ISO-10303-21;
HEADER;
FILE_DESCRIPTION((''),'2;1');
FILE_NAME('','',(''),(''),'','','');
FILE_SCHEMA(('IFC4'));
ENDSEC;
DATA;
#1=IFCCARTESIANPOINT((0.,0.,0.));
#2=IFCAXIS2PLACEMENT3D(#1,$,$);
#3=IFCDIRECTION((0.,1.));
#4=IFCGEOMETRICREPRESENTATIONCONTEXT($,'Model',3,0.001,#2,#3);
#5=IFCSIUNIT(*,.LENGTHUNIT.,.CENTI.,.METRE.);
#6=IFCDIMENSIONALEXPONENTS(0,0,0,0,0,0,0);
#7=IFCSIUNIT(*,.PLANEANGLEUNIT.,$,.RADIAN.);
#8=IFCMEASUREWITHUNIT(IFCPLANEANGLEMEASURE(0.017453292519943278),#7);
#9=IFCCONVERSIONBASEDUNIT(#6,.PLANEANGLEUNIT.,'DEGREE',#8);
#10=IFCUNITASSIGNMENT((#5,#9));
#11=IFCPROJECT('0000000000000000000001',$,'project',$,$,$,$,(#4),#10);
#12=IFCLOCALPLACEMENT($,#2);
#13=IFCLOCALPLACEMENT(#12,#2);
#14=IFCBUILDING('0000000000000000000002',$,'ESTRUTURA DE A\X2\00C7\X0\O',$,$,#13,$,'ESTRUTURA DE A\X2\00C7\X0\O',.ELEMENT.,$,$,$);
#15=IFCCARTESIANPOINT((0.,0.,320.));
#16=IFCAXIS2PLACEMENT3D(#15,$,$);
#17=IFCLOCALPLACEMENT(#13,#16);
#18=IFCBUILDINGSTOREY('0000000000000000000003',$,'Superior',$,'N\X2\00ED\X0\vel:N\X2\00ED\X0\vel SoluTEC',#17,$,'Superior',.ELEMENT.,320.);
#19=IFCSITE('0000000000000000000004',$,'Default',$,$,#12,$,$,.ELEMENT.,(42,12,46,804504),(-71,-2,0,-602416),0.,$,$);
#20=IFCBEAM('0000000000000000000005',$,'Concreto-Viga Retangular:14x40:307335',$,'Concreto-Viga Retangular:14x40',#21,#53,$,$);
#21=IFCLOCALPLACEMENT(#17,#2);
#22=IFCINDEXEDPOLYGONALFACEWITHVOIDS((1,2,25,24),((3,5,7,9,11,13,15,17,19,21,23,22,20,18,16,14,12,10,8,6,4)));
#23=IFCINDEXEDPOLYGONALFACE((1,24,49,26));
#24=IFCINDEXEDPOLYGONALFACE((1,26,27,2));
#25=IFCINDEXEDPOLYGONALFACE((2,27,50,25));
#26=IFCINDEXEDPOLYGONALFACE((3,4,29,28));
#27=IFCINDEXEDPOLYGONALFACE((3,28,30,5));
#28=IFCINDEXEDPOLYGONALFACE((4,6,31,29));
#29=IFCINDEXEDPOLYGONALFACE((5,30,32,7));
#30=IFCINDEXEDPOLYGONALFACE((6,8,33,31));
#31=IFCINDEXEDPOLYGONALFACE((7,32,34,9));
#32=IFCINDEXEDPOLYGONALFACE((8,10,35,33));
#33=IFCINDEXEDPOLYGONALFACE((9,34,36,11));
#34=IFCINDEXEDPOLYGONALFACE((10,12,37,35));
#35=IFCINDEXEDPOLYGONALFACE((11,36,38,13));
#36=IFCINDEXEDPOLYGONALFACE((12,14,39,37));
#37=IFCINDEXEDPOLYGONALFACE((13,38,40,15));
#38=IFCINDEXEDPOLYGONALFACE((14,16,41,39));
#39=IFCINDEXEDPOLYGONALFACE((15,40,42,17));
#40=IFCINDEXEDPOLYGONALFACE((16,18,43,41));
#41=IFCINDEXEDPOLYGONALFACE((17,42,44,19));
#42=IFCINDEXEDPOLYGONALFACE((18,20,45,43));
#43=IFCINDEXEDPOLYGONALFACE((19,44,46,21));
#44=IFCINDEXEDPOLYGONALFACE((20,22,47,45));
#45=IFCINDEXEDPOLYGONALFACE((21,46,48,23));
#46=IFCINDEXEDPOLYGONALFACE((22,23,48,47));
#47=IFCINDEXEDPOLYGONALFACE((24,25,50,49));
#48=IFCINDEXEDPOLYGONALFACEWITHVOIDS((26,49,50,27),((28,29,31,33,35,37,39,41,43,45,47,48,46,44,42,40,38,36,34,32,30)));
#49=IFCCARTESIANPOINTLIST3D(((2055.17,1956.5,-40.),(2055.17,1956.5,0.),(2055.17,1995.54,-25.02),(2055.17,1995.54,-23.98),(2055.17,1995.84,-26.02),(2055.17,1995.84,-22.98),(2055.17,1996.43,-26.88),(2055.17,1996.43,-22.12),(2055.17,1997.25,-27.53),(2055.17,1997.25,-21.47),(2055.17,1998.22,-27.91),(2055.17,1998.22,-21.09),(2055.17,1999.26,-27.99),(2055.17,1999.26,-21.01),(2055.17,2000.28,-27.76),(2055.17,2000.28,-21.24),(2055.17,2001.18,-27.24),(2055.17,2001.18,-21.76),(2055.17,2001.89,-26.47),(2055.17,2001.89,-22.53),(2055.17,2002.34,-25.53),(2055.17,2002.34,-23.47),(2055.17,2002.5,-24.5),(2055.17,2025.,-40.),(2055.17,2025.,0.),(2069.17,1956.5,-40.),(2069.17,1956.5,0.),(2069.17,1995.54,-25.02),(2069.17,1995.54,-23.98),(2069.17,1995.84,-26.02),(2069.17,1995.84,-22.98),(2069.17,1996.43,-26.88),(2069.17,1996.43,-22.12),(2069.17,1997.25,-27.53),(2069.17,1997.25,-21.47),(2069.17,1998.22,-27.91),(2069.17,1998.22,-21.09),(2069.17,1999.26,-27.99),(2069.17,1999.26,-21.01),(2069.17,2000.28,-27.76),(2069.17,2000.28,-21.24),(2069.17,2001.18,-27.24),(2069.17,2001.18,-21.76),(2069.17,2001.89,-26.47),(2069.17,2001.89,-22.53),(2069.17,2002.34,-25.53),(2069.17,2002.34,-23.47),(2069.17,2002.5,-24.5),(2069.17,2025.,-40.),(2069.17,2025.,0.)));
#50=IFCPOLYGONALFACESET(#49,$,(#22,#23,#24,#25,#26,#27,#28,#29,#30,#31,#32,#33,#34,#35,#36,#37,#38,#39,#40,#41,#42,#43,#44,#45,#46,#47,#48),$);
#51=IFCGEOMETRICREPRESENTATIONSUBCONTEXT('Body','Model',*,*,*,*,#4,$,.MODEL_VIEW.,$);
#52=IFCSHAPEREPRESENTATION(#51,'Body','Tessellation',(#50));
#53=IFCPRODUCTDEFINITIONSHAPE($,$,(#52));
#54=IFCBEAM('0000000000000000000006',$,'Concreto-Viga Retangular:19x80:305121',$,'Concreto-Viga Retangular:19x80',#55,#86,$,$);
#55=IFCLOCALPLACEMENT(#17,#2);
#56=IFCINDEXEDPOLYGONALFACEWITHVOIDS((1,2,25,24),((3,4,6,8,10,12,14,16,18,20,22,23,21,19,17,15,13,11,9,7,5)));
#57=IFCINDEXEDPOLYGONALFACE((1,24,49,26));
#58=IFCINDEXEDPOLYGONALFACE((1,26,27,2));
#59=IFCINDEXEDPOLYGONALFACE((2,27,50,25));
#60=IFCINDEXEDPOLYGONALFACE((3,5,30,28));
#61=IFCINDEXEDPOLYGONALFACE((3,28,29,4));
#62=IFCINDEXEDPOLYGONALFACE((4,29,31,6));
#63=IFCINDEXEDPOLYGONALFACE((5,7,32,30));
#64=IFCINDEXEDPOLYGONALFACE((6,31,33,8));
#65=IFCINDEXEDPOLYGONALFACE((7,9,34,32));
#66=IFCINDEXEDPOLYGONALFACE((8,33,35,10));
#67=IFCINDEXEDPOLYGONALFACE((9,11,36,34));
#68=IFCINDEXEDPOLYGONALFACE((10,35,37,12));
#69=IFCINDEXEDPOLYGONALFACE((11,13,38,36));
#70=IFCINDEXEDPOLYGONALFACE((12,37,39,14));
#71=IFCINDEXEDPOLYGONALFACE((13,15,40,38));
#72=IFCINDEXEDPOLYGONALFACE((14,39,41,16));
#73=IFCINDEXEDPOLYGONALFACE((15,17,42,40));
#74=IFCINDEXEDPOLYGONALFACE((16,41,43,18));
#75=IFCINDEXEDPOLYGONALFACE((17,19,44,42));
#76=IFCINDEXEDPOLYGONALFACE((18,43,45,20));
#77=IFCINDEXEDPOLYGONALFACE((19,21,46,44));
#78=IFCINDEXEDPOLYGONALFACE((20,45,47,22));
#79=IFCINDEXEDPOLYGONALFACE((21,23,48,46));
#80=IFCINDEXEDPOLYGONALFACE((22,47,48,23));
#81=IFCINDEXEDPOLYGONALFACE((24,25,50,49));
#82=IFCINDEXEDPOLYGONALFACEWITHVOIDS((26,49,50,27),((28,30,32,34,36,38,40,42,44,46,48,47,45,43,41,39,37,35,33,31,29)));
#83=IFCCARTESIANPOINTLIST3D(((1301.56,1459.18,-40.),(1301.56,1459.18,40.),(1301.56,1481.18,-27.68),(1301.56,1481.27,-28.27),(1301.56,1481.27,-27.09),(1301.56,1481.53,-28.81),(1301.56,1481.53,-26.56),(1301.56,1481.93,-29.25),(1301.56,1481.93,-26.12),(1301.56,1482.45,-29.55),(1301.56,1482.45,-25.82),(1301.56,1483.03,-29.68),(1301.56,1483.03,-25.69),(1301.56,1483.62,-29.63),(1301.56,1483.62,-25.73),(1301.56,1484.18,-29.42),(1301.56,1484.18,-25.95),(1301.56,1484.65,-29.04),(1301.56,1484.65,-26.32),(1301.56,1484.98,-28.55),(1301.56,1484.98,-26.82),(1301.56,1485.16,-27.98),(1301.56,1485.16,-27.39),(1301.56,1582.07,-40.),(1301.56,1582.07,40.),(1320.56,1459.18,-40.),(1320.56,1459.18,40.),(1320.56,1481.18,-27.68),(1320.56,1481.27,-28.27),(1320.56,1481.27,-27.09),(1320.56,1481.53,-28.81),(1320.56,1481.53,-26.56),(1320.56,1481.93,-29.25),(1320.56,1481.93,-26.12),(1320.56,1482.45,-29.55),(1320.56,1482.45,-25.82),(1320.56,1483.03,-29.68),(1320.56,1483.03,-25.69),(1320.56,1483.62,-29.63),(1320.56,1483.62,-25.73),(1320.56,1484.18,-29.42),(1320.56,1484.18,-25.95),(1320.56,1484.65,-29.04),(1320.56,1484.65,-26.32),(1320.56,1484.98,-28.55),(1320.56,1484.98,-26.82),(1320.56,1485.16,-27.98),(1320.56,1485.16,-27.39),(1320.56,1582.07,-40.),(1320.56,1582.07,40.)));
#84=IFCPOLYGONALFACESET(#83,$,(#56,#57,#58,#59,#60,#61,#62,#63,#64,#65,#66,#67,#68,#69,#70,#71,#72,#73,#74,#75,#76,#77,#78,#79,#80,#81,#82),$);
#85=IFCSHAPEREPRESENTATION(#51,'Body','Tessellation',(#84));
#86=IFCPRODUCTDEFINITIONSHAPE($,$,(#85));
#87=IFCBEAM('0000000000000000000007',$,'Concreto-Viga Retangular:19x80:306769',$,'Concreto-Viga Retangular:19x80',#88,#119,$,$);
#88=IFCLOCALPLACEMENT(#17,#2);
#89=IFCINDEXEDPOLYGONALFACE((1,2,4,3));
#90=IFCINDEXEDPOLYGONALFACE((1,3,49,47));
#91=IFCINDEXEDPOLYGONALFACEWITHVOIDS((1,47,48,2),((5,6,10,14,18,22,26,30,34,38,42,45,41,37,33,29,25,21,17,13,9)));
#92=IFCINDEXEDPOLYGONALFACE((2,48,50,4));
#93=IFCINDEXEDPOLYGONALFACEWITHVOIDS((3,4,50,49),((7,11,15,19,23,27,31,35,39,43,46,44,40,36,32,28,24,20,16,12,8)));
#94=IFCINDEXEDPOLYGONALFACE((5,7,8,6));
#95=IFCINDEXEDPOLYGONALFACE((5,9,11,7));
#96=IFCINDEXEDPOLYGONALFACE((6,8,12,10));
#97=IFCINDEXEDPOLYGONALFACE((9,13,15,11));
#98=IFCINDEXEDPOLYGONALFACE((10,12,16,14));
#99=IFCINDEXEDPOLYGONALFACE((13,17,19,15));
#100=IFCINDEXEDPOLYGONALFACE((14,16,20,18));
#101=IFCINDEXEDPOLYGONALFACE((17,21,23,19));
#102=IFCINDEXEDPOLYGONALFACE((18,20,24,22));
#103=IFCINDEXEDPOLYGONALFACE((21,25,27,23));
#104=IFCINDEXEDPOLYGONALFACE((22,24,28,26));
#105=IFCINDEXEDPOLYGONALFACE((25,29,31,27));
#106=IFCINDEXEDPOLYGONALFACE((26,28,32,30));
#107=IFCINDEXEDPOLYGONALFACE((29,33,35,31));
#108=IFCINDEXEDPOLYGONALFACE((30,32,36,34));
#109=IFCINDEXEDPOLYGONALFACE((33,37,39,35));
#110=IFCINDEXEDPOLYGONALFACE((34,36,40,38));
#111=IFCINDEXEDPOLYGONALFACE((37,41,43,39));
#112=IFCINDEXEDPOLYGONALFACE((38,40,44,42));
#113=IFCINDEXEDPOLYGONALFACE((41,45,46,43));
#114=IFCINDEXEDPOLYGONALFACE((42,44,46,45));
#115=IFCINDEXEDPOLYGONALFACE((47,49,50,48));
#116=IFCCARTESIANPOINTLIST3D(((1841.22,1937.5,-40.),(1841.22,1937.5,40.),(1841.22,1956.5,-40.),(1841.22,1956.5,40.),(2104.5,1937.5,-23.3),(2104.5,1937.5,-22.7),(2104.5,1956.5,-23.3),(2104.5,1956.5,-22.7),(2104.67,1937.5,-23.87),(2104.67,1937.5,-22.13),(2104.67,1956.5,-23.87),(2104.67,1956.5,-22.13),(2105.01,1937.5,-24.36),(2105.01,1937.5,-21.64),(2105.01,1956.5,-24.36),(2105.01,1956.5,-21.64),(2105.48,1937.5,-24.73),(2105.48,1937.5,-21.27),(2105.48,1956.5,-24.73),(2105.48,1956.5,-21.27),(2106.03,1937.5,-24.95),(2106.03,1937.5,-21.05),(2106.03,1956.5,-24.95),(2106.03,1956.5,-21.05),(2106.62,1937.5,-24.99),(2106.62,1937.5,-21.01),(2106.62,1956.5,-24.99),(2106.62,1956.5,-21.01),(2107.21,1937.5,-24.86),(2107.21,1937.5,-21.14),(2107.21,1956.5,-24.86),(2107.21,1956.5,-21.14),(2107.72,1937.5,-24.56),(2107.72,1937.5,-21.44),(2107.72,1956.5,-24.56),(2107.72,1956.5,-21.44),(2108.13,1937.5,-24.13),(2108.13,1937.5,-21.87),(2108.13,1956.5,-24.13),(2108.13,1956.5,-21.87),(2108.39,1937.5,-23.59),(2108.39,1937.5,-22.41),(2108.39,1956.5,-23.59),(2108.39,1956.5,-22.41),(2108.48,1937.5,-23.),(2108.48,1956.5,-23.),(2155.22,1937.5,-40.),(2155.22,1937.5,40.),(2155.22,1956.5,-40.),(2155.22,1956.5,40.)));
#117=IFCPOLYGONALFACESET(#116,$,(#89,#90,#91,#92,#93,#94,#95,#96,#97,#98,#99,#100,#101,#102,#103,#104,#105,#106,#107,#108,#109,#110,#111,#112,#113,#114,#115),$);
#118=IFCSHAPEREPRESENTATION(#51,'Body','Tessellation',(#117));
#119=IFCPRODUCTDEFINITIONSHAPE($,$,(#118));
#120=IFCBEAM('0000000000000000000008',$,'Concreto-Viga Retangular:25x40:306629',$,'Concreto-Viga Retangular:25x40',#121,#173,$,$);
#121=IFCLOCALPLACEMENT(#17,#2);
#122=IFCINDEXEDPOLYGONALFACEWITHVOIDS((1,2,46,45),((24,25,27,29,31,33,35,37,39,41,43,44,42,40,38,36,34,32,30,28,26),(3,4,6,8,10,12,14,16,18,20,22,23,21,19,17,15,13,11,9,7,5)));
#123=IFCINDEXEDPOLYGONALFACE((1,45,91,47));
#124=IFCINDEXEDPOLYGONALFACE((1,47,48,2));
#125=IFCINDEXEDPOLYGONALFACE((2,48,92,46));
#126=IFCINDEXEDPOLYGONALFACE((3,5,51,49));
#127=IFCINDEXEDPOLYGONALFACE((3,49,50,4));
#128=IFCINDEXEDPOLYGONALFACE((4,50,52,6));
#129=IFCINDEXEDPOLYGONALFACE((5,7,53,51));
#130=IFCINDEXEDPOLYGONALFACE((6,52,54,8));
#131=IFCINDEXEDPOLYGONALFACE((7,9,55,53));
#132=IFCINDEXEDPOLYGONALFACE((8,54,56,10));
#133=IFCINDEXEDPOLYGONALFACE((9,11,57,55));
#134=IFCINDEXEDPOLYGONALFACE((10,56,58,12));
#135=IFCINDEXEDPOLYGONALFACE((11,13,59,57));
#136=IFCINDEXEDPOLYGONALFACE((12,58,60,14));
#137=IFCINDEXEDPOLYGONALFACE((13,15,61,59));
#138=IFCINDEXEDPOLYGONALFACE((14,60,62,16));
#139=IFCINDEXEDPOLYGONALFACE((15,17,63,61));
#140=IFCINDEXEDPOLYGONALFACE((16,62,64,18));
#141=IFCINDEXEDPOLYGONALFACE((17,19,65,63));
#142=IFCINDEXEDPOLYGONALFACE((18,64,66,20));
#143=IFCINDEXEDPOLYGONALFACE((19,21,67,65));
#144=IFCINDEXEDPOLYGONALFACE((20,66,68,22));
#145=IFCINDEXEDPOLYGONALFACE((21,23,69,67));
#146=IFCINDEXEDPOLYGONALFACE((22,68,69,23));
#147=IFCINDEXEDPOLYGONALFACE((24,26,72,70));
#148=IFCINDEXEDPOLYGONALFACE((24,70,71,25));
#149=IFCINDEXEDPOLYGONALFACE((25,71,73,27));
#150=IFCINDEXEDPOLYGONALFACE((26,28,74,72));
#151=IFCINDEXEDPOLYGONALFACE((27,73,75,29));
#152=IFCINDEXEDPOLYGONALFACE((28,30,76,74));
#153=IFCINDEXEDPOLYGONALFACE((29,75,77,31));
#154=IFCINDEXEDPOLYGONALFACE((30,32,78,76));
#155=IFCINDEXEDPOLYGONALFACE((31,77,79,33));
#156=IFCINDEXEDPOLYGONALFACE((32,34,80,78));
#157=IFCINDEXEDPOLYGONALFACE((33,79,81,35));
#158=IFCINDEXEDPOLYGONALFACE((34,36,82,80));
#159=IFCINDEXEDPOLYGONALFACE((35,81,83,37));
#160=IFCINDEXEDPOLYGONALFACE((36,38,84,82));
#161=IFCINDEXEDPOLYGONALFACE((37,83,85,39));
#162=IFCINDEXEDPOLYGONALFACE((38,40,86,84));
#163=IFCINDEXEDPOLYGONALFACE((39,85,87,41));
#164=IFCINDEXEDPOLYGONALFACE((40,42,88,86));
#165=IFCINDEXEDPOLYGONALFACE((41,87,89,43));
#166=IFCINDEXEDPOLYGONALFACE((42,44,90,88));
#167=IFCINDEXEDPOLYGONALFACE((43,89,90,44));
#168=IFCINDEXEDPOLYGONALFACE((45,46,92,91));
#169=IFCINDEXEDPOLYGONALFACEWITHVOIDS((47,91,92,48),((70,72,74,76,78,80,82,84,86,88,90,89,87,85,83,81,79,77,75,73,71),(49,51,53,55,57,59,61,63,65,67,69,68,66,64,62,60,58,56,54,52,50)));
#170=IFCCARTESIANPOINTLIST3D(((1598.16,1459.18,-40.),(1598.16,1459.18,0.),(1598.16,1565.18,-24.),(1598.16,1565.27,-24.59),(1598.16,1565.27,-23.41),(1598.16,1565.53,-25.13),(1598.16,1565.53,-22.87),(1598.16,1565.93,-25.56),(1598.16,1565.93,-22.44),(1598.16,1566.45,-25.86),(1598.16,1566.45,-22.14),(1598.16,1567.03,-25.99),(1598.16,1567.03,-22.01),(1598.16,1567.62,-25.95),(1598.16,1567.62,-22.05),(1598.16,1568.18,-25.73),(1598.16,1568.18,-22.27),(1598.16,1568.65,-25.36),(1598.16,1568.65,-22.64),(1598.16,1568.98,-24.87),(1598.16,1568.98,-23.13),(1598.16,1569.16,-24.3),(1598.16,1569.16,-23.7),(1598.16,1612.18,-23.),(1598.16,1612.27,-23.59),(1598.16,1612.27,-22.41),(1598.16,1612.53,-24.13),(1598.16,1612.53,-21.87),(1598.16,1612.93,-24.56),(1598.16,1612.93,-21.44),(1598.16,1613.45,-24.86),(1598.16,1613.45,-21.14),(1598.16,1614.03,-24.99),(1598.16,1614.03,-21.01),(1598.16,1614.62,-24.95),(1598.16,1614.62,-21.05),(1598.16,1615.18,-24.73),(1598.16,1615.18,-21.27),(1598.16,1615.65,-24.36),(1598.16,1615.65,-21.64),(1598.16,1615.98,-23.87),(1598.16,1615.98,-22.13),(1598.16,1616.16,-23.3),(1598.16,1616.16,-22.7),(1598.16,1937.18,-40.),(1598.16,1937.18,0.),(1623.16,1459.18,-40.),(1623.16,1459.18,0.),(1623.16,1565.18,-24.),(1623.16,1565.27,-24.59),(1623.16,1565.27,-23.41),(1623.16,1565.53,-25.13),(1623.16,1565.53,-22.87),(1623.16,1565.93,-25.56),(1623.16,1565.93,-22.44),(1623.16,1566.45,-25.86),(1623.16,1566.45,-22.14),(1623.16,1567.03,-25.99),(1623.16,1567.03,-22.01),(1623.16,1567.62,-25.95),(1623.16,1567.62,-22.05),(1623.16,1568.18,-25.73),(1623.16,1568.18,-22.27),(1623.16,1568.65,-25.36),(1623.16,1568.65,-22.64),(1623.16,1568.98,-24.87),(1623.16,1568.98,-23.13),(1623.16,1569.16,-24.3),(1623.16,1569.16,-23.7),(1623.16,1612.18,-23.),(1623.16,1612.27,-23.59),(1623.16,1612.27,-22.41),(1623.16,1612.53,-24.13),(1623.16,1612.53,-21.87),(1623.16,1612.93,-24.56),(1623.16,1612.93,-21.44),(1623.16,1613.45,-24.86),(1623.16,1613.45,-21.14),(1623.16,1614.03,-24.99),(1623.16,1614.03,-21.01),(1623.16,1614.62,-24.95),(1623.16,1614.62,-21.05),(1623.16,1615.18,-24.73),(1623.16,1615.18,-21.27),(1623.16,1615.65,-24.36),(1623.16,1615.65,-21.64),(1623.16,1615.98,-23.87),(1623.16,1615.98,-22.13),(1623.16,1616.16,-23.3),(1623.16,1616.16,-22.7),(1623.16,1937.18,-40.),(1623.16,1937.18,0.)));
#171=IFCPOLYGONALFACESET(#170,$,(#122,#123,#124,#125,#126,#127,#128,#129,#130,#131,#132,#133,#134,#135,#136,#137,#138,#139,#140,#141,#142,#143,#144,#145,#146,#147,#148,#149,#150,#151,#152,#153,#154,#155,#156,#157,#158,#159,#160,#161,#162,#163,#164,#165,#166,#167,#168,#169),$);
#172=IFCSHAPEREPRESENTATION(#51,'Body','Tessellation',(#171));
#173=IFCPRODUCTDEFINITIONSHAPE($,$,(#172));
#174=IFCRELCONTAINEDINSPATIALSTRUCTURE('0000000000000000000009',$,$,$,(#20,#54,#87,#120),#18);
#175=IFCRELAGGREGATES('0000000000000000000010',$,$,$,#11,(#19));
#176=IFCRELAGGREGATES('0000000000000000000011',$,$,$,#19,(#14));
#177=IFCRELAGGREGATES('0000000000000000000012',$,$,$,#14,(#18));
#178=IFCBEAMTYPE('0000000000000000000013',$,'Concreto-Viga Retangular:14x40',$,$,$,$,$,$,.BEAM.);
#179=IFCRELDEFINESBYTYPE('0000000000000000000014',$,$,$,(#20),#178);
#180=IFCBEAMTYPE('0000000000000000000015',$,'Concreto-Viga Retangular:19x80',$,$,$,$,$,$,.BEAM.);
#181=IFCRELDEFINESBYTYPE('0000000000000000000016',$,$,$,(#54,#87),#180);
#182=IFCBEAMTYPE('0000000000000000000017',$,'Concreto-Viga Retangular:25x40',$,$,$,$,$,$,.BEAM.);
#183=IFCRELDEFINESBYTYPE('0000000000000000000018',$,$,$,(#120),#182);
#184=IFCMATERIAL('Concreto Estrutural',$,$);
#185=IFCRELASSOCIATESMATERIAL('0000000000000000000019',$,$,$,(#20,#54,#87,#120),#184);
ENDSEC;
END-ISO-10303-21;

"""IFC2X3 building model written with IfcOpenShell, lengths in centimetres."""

from ifc_helpers import new_model, entity, si_unit, converted_unit, direction, frame, frame_2d, origin, origin_2d_with_axis, place, context, subcontext, project, spatial, rectangle, circle, extrude, boolean, material, type_object, element, save


model = new_model("IFC2X3")

# Units and contexts
model_context = context("Model", 3, precision=0.001, world=origin(), true_north=direction((0.0, 1.0)))
body_context = subcontext(model_context, "Body", "Model", "MODEL_VIEW")
ifc_project = project(units=[si_unit("LENGTHUNIT", "METRE", prefix="CENTI"), converted_unit("PLANEANGLEUNIT", "DEGREE", entity("IfcPlaneAngleMeasure", 0.017453292519943278), si_unit("PLANEANGLEUNIT", "RADIAN"), dimensions=[0, 0, 0, 0, 0, 0, 0])], contexts=[model_context])

# Site, building, storey
site_placement = place(None, origin())
site = spatial("IfcSite", under=ifc_project, at=site_placement, Name="Default", CompositionType="ELEMENT", RefLatitude=(42, 12, 46, 804504), RefLongitude=(-71, -2, 0, -602416), RefElevation=0.0)
building_placement = place(site_placement, origin())
building = spatial("IfcBuilding", under=site, at=building_placement, Name="ESTRUTURA DE AÇO", LongName="ESTRUTURA DE AÇO", CompositionType="ELEMENT")
storey_placement = place(building_placement, frame((0.0, 0.0, 320.0)))
storey = spatial("IfcBuildingStorey", under=building, at=storey_placement, Name="Superior", ObjectType="Nível:Nível SoluTEC", LongName="Superior", CompositionType="ELEMENT", Elevation=320.0)

# Shared definitions
ifc_material = material(Name="Concreto Estrutural")

# Beams
beam_type_1 = type_object("IfcBeamType", Name="Concreto-Viga Retangular:14x40", PredefinedType="BEAM")
beam_1_placement = place(storey_placement, frame((2062.17, 1947.0, 0.0), z_axis=(0.0, 0.0, 1.0), x_axis=(0.0, 1.0, 0.0)))
element("IfcBeam", 1, at=beam_1_placement, inside=storey, type_object=beam_type_1, material=ifc_material, Name="Concreto-Viga Retangular:14x40:307335", ObjectType="Concreto-Viga Retangular:14x40", context=body_context, shape_type="SweptSolid", body=[
    boolean("DIFFERENCE", extrude(rectangle(XDim=40.0, YDim=14.0, at=frame_2d((0.0, 0.0), x_axis=(0.0, 1.0))), frame((9.5, 0.0, -20.0), z_axis=(1.0, 0.0, 0.0), x_axis=(0.0, 1.0, 0.0)), (0.0, 0.0, 1.0), 68.5), extrude(circle(Radius=3.5, at=origin_2d_with_axis()), frame((52.0, -7.0, -24.5), z_axis=(0.0, 1.0, 0.0), x_axis=(1.0, 0.0, 0.0)), (0.0, 0.0, 1.0), 14.0)),
])
beam_type_2 = type_object("IfcBeamType", Name="Concreto-Viga Retangular:19x80", PredefinedType="BEAM")
beam_2_placement = place(storey_placement, frame((1311.06, 1582.68, 0.0), z_axis=(0.0, 0.0, 1.0), x_axis=(0.0, -1.0, 0.0)))
element("IfcBeam", 2, at=beam_2_placement, inside=storey, type_object=beam_type_2, material=ifc_material, Name="Concreto-Viga Retangular:19x80:305121", ObjectType="Concreto-Viga Retangular:19x80", context=body_context, shape_type="SweptSolid", body=[
    boolean("DIFFERENCE", extrude(rectangle(XDim=80.0, YDim=19.0, at=frame_2d((0.0, 0.0), x_axis=(0.0, 1.0))), frame((0.61, 0.0, 0.0), z_axis=(1.0, 0.0, 0.0), x_axis=(0.0, 1.0, 0.0)), (0.0, 0.0, 1.0), 122.89), extrude(circle(Radius=2.0, at=origin_2d_with_axis()), frame((99.5, 9.5, -27.68), z_axis=(0.0, -1.0, 0.0), x_axis=(1.0, 0.0, 0.0)), (0.0, 0.0, 1.0), 19.0)),
])
beam_3_placement = place(storey_placement, frame((1841.22, 1947.0, 0.0)))
element("IfcBeam", 3, at=beam_3_placement, inside=storey, type_object=beam_type_2, material=ifc_material, Name="Concreto-Viga Retangular:19x80:306769", ObjectType="Concreto-Viga Retangular:19x80", context=body_context, shape_type="SweptSolid", body=[
    boolean("DIFFERENCE", extrude(rectangle(XDim=80.0, YDim=19.0, at=frame_2d((0.0, 0.0), x_axis=(0.0, 1.0))), frame((0.0, 0.0, 0.0), z_axis=(1.0, 0.0, 0.0), x_axis=(0.0, 1.0, 0.0)), (0.0, 0.0, 1.0), 314.0), extrude(circle(Radius=2.0, at=origin_2d_with_axis()), frame((265.25, 9.5, -23.0), z_axis=(0.0, -1.0, 0.0), x_axis=(1.0, 0.0, 0.0)), (0.0, 0.0, 1.0), 19.0)),
])
beam_type_3 = type_object("IfcBeamType", Name="Concreto-Viga Retangular:25x40", PredefinedType="BEAM")
beam_4_placement = place(storey_placement, frame((1610.66, 1937.18, 0.0), z_axis=(0.0, 0.0, 1.0), x_axis=(0.0, -1.0, 0.0)))
element("IfcBeam", 4, at=beam_4_placement, inside=storey, type_object=beam_type_3, material=ifc_material, Name="Concreto-Viga Retangular:25x40:306629", ObjectType="Concreto-Viga Retangular:25x40", context=body_context, shape_type="SweptSolid", body=[
    boolean("DIFFERENCE", boolean("DIFFERENCE", extrude(rectangle(XDim=40.0, YDim=25.0, at=frame_2d((0.0, 0.0), x_axis=(0.0, 1.0))), frame((0.0, 0.0, -20.0), z_axis=(1.0, 0.0, 0.0), x_axis=(0.0, 1.0, 0.0)), (0.0, 0.0, 1.0), 478.0), extrude(circle(Radius=2.0, at=origin_2d_with_axis()), frame((323.0, 12.5, -23.0), z_axis=(0.0, -1.0, 0.0), x_axis=(1.0, 0.0, 0.0)), (0.0, 0.0, 1.0), 25.0)), extrude(circle(Radius=2.0, at=origin_2d_with_axis()), frame((370.0, 12.5, -24.0), z_axis=(0.0, -1.0, 0.0), x_axis=(1.0, 0.0, 0.0)), (0.0, 0.0, 1.0), 25.0)),
])

save(model, "model.ifc")
